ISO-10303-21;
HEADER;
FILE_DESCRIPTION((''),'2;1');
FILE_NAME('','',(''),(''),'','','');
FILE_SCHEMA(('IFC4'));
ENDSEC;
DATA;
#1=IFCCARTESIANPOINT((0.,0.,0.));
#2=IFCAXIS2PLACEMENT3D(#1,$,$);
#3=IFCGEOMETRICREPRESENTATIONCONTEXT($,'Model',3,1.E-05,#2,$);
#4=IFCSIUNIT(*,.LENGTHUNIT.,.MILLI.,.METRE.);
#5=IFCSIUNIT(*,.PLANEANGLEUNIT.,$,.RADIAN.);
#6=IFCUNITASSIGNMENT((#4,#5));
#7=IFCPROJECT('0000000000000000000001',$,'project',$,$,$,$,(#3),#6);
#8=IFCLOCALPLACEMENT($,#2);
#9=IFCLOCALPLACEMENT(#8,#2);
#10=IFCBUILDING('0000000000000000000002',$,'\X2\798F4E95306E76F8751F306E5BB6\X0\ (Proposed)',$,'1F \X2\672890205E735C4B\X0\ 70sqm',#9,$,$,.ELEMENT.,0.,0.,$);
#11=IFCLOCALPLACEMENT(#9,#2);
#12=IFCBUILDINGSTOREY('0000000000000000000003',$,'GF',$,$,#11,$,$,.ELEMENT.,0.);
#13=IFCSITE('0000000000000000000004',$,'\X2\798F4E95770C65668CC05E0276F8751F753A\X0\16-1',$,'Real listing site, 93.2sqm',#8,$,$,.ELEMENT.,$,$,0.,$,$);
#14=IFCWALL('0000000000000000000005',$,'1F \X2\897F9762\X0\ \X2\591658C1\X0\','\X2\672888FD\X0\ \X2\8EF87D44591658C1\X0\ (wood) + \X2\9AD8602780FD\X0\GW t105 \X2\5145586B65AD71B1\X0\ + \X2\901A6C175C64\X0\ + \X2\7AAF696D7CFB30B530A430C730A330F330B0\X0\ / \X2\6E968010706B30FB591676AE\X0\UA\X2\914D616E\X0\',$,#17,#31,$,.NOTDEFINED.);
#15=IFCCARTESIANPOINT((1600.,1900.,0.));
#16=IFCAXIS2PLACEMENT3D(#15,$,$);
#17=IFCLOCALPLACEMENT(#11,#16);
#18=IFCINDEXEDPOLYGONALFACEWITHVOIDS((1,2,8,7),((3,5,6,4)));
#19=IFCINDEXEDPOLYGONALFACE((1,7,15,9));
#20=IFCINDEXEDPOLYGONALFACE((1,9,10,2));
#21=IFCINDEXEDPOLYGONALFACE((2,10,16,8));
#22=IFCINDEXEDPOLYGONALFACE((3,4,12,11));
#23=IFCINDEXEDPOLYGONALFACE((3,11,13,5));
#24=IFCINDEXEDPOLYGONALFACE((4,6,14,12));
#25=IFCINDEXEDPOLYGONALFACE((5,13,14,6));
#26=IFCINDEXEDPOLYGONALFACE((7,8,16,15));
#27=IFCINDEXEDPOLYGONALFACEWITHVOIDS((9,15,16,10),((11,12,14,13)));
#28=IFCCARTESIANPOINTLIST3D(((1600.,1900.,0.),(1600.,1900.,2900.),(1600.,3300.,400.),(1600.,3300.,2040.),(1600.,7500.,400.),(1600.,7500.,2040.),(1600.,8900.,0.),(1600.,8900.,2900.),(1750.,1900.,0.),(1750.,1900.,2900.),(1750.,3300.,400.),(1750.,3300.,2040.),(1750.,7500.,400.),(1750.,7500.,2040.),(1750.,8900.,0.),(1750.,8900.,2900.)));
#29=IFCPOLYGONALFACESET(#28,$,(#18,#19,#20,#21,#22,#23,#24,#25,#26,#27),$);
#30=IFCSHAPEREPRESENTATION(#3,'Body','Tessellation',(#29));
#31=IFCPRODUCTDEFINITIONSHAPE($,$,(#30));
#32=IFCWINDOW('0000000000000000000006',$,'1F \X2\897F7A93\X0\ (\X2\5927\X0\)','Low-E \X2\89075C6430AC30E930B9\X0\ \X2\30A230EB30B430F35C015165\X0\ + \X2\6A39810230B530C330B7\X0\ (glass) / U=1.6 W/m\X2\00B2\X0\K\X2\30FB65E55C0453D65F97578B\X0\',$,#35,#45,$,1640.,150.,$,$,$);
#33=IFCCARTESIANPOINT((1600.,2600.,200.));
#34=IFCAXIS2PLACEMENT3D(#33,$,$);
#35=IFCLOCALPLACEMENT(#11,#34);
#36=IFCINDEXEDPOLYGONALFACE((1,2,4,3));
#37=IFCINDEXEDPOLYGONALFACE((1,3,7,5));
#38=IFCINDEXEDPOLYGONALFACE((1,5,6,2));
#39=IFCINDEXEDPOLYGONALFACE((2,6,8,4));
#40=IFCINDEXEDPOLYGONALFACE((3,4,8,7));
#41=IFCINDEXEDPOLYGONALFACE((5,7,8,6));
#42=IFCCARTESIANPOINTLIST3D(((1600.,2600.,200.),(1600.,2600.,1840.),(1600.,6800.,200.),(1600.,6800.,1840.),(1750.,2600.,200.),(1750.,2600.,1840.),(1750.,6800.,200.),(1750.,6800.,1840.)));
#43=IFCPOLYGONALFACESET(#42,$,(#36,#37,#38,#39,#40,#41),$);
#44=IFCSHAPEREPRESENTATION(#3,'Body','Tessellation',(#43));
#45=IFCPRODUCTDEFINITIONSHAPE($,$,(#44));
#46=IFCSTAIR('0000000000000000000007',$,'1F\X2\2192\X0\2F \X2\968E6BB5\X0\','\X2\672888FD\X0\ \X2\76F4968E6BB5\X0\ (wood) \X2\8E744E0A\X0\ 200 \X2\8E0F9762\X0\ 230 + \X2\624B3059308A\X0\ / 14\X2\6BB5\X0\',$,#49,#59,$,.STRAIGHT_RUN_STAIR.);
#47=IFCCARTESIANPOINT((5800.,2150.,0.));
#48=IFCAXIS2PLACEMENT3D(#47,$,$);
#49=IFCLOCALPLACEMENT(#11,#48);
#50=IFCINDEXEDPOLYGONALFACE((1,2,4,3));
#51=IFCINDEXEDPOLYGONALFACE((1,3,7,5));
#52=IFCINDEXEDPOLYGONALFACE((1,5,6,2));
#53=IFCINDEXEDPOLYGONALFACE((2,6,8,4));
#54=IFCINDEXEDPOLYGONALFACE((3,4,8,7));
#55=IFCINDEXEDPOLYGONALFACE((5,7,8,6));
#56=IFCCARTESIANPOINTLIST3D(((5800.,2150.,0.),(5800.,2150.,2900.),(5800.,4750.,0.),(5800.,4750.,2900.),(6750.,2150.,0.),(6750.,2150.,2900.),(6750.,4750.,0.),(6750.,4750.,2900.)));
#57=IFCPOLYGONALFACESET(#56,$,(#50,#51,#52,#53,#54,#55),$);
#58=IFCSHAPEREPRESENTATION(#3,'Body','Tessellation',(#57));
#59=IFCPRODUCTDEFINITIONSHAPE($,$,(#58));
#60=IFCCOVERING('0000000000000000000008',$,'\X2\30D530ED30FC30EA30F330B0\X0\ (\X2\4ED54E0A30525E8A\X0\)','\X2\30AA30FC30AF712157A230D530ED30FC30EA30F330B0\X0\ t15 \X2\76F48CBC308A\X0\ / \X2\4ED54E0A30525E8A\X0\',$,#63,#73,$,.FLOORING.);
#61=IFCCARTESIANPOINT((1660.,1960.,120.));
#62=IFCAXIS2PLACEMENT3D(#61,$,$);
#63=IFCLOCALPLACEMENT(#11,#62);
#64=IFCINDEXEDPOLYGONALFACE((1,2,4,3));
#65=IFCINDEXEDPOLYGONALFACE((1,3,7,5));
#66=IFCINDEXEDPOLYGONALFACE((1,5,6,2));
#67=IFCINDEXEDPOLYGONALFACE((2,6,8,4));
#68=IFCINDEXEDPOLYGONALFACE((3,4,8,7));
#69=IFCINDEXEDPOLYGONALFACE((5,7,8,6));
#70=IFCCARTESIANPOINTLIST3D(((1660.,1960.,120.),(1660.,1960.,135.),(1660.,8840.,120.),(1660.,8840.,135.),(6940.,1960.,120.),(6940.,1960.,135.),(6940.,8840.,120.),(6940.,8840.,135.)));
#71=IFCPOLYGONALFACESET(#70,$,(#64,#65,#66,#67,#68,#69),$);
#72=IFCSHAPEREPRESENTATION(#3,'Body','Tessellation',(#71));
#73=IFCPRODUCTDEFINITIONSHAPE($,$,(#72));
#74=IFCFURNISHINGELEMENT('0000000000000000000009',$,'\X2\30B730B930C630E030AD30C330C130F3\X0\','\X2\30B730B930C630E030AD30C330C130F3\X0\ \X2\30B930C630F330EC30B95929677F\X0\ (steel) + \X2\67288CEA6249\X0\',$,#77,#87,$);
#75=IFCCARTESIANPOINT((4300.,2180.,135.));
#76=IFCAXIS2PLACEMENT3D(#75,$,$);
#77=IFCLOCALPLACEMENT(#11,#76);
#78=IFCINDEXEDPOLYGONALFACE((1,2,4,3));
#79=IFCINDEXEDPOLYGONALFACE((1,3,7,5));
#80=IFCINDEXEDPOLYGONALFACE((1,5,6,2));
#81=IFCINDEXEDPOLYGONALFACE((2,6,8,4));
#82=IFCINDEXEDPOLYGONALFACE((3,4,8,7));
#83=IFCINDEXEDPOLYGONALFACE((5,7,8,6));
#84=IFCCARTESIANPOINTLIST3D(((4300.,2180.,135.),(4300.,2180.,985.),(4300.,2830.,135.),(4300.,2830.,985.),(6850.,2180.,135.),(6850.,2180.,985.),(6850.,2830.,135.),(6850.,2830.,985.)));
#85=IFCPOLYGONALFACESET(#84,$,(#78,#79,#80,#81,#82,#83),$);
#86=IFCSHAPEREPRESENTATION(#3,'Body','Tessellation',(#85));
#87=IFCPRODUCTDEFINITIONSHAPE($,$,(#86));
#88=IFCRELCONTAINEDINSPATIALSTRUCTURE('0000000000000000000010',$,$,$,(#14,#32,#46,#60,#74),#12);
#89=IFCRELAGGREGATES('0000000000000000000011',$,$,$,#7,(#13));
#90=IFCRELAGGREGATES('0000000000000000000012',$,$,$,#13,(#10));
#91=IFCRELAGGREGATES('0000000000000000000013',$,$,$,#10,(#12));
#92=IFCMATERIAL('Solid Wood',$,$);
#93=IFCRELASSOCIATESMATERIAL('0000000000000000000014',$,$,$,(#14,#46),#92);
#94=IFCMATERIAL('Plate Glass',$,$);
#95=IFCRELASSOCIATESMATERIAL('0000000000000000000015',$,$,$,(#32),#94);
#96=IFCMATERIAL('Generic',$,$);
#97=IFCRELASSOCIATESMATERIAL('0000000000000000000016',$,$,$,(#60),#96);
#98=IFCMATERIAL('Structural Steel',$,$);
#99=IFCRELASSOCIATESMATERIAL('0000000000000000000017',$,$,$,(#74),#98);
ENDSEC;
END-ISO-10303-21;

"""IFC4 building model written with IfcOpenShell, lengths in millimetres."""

from ifc_helpers import new_model, si_unit, frame, frame_2d, origin, place, context, project, spatial, rectangle, extrude, material, element, fill, save


model = new_model("IFC4")

# Units and contexts
model_context = context("Model", 3, precision=1e-05, world=origin())
ifc_project = project(units=[si_unit("LENGTHUNIT", "METRE", prefix="MILLI"), si_unit("PLANEANGLEUNIT", "RADIAN")], contexts=[model_context])

# Site, building, storey
site_placement = place(None, origin())
site = spatial("IfcSite", under=ifc_project, at=site_placement, Name="福井県敦賀市相生町16-1", ObjectType="Real listing site, 93.2sqm", CompositionType="ELEMENT", RefElevation=0.0)
building_placement = place(site_placement, origin())
building = spatial("IfcBuilding", under=site, at=building_placement, Name="福井の相生の家 (Proposed)", ObjectType="1F 木造平屋 70sqm", CompositionType="ELEMENT", ElevationOfRefHeight=0.0, ElevationOfTerrain=0.0)
storey_placement = place(building_placement, origin())
storey = spatial("IfcBuildingStorey", under=building, at=storey_placement, Name="GF", CompositionType="ELEMENT", Elevation=0.0)

# Shared definitions
ifc_material_1 = material(Name="Solid Wood")
ifc_material_2 = material(Name="Generic")

# Shared definitions
ifc_material_3 = material(Name="Plate Glass")

# Wall, opening, window
wall_1_placement = place(storey_placement, frame((1600.0, 1900.0, 0.0)))
wall_1 = element("IfcWall", 1, at=wall_1_placement, inside=storey, material=ifc_material_1, Name="1F 西面 外壁", Description="木製 軸組外壁 (wood) + 高性能GW t105 充填断熱 + 通気層 + 窯業系サイディング / 準耐火・外皮UA配慮", PredefinedType="NOTDEFINED", context=model_context, shape_type="SweptSolid", body=[
    extrude(rectangle(XDim=150.0, YDim=7000.0, at=frame_2d((75.0, 3500.0))), frame((1600.0, 1900.0, 0.0)), (0.0, 0.0, 1.0), 2900.0),
])
opening_1_placement = place(storey_placement, frame((1600.0, 2600.0, 200.0)))
opening_1 = element("IfcOpeningElement", 2, at=opening_1_placement, cuts=wall_1, PredefinedType="NOTDEFINED", context=model_context, shape_type="SweptSolid", body=[
    extrude(rectangle(XDim=150.0, YDim=4200.0, at=frame_2d((75.0, 2100.0))), frame((1600.0, 2600.0, 200.0)), (0.0, 0.0, 1.0), 1640.0),
])
window_1_placement = place(storey_placement, frame((1600.0, 2600.0, 200.0)))
window_1 = element("IfcWindow", 3, at=window_1_placement, inside=storey, material=ifc_material_3, Name="1F 西窓 (大)", Description="Low-E 複層ガラス アルゴン封入 + 樹脂サッシ (glass) / U=1.6 W/m²K・日射取得型", OverallHeight=1640.0, OverallWidth=150.0, context=model_context, shape_type="SweptSolid", body=[
    extrude(rectangle(XDim=150.0, YDim=4200.0, at=frame_2d((75.0, 2100.0))), frame((1600.0, 2600.0, 200.0)), (0.0, 0.0, 1.0), 1640.0),
])
fill(opening_1, window_1)

# Stair
stair_placement = place(storey_placement, frame((5800.0, 2150.0, 0.0)))
element("IfcStair", 4, at=stair_placement, inside=storey, material=ifc_material_1, Name="1F→2F 階段", Description="木製 直階段 (wood) 蹴上 200 踏面 230 + 手すり / 14段", PredefinedType="STRAIGHT_RUN_STAIR", context=model_context, shape_type="SweptSolid", body=[
    extrude(rectangle(XDim=950.0, YDim=2600.0, at=frame_2d((475.0, 1300.0))), frame((5800.0, 2150.0, 0.0)), (0.0, 0.0, 1.0), 2900.0),
])

# Covering
covering_placement = place(storey_placement, frame((1660.0, 1960.0, 120.0)))
element("IfcCovering", 5, at=covering_placement, inside=storey, material=ifc_material_2, Name="フローリング (仕上げ床)", Description="オーク無垢フローリング t15 直貼り / 仕上げ床", PredefinedType="FLOORING", context=model_context, shape_type="SweptSolid", body=[
    extrude(rectangle(XDim=5280.0, YDim=6880.0, at=frame_2d((2640.0, 3440.0))), frame((1660.0, 1960.0, 120.0)), (0.0, 0.0, 1.0), 15.0),
])

# Furnishing element
ifc_material_4 = material(Name="Structural Steel")
furnishing_placement = place(storey_placement, frame((4300.0, 2180.0, 135.0)))
element("IfcFurnishingElement", 6, at=furnishing_placement, inside=storey, material=ifc_material_4, Name="システムキッチン", Description="システムキッチン ステンレス天板 (steel) + 木質扉", context=model_context, shape_type="SweptSolid", body=[
    extrude(rectangle(XDim=2550.0, YDim=650.0, at=frame_2d((1275.0, 325.0))), frame((4300.0, 2180.0, 135.0)), (0.0, 0.0, 1.0), 850.0),
])

save(model, "model.ifc")
